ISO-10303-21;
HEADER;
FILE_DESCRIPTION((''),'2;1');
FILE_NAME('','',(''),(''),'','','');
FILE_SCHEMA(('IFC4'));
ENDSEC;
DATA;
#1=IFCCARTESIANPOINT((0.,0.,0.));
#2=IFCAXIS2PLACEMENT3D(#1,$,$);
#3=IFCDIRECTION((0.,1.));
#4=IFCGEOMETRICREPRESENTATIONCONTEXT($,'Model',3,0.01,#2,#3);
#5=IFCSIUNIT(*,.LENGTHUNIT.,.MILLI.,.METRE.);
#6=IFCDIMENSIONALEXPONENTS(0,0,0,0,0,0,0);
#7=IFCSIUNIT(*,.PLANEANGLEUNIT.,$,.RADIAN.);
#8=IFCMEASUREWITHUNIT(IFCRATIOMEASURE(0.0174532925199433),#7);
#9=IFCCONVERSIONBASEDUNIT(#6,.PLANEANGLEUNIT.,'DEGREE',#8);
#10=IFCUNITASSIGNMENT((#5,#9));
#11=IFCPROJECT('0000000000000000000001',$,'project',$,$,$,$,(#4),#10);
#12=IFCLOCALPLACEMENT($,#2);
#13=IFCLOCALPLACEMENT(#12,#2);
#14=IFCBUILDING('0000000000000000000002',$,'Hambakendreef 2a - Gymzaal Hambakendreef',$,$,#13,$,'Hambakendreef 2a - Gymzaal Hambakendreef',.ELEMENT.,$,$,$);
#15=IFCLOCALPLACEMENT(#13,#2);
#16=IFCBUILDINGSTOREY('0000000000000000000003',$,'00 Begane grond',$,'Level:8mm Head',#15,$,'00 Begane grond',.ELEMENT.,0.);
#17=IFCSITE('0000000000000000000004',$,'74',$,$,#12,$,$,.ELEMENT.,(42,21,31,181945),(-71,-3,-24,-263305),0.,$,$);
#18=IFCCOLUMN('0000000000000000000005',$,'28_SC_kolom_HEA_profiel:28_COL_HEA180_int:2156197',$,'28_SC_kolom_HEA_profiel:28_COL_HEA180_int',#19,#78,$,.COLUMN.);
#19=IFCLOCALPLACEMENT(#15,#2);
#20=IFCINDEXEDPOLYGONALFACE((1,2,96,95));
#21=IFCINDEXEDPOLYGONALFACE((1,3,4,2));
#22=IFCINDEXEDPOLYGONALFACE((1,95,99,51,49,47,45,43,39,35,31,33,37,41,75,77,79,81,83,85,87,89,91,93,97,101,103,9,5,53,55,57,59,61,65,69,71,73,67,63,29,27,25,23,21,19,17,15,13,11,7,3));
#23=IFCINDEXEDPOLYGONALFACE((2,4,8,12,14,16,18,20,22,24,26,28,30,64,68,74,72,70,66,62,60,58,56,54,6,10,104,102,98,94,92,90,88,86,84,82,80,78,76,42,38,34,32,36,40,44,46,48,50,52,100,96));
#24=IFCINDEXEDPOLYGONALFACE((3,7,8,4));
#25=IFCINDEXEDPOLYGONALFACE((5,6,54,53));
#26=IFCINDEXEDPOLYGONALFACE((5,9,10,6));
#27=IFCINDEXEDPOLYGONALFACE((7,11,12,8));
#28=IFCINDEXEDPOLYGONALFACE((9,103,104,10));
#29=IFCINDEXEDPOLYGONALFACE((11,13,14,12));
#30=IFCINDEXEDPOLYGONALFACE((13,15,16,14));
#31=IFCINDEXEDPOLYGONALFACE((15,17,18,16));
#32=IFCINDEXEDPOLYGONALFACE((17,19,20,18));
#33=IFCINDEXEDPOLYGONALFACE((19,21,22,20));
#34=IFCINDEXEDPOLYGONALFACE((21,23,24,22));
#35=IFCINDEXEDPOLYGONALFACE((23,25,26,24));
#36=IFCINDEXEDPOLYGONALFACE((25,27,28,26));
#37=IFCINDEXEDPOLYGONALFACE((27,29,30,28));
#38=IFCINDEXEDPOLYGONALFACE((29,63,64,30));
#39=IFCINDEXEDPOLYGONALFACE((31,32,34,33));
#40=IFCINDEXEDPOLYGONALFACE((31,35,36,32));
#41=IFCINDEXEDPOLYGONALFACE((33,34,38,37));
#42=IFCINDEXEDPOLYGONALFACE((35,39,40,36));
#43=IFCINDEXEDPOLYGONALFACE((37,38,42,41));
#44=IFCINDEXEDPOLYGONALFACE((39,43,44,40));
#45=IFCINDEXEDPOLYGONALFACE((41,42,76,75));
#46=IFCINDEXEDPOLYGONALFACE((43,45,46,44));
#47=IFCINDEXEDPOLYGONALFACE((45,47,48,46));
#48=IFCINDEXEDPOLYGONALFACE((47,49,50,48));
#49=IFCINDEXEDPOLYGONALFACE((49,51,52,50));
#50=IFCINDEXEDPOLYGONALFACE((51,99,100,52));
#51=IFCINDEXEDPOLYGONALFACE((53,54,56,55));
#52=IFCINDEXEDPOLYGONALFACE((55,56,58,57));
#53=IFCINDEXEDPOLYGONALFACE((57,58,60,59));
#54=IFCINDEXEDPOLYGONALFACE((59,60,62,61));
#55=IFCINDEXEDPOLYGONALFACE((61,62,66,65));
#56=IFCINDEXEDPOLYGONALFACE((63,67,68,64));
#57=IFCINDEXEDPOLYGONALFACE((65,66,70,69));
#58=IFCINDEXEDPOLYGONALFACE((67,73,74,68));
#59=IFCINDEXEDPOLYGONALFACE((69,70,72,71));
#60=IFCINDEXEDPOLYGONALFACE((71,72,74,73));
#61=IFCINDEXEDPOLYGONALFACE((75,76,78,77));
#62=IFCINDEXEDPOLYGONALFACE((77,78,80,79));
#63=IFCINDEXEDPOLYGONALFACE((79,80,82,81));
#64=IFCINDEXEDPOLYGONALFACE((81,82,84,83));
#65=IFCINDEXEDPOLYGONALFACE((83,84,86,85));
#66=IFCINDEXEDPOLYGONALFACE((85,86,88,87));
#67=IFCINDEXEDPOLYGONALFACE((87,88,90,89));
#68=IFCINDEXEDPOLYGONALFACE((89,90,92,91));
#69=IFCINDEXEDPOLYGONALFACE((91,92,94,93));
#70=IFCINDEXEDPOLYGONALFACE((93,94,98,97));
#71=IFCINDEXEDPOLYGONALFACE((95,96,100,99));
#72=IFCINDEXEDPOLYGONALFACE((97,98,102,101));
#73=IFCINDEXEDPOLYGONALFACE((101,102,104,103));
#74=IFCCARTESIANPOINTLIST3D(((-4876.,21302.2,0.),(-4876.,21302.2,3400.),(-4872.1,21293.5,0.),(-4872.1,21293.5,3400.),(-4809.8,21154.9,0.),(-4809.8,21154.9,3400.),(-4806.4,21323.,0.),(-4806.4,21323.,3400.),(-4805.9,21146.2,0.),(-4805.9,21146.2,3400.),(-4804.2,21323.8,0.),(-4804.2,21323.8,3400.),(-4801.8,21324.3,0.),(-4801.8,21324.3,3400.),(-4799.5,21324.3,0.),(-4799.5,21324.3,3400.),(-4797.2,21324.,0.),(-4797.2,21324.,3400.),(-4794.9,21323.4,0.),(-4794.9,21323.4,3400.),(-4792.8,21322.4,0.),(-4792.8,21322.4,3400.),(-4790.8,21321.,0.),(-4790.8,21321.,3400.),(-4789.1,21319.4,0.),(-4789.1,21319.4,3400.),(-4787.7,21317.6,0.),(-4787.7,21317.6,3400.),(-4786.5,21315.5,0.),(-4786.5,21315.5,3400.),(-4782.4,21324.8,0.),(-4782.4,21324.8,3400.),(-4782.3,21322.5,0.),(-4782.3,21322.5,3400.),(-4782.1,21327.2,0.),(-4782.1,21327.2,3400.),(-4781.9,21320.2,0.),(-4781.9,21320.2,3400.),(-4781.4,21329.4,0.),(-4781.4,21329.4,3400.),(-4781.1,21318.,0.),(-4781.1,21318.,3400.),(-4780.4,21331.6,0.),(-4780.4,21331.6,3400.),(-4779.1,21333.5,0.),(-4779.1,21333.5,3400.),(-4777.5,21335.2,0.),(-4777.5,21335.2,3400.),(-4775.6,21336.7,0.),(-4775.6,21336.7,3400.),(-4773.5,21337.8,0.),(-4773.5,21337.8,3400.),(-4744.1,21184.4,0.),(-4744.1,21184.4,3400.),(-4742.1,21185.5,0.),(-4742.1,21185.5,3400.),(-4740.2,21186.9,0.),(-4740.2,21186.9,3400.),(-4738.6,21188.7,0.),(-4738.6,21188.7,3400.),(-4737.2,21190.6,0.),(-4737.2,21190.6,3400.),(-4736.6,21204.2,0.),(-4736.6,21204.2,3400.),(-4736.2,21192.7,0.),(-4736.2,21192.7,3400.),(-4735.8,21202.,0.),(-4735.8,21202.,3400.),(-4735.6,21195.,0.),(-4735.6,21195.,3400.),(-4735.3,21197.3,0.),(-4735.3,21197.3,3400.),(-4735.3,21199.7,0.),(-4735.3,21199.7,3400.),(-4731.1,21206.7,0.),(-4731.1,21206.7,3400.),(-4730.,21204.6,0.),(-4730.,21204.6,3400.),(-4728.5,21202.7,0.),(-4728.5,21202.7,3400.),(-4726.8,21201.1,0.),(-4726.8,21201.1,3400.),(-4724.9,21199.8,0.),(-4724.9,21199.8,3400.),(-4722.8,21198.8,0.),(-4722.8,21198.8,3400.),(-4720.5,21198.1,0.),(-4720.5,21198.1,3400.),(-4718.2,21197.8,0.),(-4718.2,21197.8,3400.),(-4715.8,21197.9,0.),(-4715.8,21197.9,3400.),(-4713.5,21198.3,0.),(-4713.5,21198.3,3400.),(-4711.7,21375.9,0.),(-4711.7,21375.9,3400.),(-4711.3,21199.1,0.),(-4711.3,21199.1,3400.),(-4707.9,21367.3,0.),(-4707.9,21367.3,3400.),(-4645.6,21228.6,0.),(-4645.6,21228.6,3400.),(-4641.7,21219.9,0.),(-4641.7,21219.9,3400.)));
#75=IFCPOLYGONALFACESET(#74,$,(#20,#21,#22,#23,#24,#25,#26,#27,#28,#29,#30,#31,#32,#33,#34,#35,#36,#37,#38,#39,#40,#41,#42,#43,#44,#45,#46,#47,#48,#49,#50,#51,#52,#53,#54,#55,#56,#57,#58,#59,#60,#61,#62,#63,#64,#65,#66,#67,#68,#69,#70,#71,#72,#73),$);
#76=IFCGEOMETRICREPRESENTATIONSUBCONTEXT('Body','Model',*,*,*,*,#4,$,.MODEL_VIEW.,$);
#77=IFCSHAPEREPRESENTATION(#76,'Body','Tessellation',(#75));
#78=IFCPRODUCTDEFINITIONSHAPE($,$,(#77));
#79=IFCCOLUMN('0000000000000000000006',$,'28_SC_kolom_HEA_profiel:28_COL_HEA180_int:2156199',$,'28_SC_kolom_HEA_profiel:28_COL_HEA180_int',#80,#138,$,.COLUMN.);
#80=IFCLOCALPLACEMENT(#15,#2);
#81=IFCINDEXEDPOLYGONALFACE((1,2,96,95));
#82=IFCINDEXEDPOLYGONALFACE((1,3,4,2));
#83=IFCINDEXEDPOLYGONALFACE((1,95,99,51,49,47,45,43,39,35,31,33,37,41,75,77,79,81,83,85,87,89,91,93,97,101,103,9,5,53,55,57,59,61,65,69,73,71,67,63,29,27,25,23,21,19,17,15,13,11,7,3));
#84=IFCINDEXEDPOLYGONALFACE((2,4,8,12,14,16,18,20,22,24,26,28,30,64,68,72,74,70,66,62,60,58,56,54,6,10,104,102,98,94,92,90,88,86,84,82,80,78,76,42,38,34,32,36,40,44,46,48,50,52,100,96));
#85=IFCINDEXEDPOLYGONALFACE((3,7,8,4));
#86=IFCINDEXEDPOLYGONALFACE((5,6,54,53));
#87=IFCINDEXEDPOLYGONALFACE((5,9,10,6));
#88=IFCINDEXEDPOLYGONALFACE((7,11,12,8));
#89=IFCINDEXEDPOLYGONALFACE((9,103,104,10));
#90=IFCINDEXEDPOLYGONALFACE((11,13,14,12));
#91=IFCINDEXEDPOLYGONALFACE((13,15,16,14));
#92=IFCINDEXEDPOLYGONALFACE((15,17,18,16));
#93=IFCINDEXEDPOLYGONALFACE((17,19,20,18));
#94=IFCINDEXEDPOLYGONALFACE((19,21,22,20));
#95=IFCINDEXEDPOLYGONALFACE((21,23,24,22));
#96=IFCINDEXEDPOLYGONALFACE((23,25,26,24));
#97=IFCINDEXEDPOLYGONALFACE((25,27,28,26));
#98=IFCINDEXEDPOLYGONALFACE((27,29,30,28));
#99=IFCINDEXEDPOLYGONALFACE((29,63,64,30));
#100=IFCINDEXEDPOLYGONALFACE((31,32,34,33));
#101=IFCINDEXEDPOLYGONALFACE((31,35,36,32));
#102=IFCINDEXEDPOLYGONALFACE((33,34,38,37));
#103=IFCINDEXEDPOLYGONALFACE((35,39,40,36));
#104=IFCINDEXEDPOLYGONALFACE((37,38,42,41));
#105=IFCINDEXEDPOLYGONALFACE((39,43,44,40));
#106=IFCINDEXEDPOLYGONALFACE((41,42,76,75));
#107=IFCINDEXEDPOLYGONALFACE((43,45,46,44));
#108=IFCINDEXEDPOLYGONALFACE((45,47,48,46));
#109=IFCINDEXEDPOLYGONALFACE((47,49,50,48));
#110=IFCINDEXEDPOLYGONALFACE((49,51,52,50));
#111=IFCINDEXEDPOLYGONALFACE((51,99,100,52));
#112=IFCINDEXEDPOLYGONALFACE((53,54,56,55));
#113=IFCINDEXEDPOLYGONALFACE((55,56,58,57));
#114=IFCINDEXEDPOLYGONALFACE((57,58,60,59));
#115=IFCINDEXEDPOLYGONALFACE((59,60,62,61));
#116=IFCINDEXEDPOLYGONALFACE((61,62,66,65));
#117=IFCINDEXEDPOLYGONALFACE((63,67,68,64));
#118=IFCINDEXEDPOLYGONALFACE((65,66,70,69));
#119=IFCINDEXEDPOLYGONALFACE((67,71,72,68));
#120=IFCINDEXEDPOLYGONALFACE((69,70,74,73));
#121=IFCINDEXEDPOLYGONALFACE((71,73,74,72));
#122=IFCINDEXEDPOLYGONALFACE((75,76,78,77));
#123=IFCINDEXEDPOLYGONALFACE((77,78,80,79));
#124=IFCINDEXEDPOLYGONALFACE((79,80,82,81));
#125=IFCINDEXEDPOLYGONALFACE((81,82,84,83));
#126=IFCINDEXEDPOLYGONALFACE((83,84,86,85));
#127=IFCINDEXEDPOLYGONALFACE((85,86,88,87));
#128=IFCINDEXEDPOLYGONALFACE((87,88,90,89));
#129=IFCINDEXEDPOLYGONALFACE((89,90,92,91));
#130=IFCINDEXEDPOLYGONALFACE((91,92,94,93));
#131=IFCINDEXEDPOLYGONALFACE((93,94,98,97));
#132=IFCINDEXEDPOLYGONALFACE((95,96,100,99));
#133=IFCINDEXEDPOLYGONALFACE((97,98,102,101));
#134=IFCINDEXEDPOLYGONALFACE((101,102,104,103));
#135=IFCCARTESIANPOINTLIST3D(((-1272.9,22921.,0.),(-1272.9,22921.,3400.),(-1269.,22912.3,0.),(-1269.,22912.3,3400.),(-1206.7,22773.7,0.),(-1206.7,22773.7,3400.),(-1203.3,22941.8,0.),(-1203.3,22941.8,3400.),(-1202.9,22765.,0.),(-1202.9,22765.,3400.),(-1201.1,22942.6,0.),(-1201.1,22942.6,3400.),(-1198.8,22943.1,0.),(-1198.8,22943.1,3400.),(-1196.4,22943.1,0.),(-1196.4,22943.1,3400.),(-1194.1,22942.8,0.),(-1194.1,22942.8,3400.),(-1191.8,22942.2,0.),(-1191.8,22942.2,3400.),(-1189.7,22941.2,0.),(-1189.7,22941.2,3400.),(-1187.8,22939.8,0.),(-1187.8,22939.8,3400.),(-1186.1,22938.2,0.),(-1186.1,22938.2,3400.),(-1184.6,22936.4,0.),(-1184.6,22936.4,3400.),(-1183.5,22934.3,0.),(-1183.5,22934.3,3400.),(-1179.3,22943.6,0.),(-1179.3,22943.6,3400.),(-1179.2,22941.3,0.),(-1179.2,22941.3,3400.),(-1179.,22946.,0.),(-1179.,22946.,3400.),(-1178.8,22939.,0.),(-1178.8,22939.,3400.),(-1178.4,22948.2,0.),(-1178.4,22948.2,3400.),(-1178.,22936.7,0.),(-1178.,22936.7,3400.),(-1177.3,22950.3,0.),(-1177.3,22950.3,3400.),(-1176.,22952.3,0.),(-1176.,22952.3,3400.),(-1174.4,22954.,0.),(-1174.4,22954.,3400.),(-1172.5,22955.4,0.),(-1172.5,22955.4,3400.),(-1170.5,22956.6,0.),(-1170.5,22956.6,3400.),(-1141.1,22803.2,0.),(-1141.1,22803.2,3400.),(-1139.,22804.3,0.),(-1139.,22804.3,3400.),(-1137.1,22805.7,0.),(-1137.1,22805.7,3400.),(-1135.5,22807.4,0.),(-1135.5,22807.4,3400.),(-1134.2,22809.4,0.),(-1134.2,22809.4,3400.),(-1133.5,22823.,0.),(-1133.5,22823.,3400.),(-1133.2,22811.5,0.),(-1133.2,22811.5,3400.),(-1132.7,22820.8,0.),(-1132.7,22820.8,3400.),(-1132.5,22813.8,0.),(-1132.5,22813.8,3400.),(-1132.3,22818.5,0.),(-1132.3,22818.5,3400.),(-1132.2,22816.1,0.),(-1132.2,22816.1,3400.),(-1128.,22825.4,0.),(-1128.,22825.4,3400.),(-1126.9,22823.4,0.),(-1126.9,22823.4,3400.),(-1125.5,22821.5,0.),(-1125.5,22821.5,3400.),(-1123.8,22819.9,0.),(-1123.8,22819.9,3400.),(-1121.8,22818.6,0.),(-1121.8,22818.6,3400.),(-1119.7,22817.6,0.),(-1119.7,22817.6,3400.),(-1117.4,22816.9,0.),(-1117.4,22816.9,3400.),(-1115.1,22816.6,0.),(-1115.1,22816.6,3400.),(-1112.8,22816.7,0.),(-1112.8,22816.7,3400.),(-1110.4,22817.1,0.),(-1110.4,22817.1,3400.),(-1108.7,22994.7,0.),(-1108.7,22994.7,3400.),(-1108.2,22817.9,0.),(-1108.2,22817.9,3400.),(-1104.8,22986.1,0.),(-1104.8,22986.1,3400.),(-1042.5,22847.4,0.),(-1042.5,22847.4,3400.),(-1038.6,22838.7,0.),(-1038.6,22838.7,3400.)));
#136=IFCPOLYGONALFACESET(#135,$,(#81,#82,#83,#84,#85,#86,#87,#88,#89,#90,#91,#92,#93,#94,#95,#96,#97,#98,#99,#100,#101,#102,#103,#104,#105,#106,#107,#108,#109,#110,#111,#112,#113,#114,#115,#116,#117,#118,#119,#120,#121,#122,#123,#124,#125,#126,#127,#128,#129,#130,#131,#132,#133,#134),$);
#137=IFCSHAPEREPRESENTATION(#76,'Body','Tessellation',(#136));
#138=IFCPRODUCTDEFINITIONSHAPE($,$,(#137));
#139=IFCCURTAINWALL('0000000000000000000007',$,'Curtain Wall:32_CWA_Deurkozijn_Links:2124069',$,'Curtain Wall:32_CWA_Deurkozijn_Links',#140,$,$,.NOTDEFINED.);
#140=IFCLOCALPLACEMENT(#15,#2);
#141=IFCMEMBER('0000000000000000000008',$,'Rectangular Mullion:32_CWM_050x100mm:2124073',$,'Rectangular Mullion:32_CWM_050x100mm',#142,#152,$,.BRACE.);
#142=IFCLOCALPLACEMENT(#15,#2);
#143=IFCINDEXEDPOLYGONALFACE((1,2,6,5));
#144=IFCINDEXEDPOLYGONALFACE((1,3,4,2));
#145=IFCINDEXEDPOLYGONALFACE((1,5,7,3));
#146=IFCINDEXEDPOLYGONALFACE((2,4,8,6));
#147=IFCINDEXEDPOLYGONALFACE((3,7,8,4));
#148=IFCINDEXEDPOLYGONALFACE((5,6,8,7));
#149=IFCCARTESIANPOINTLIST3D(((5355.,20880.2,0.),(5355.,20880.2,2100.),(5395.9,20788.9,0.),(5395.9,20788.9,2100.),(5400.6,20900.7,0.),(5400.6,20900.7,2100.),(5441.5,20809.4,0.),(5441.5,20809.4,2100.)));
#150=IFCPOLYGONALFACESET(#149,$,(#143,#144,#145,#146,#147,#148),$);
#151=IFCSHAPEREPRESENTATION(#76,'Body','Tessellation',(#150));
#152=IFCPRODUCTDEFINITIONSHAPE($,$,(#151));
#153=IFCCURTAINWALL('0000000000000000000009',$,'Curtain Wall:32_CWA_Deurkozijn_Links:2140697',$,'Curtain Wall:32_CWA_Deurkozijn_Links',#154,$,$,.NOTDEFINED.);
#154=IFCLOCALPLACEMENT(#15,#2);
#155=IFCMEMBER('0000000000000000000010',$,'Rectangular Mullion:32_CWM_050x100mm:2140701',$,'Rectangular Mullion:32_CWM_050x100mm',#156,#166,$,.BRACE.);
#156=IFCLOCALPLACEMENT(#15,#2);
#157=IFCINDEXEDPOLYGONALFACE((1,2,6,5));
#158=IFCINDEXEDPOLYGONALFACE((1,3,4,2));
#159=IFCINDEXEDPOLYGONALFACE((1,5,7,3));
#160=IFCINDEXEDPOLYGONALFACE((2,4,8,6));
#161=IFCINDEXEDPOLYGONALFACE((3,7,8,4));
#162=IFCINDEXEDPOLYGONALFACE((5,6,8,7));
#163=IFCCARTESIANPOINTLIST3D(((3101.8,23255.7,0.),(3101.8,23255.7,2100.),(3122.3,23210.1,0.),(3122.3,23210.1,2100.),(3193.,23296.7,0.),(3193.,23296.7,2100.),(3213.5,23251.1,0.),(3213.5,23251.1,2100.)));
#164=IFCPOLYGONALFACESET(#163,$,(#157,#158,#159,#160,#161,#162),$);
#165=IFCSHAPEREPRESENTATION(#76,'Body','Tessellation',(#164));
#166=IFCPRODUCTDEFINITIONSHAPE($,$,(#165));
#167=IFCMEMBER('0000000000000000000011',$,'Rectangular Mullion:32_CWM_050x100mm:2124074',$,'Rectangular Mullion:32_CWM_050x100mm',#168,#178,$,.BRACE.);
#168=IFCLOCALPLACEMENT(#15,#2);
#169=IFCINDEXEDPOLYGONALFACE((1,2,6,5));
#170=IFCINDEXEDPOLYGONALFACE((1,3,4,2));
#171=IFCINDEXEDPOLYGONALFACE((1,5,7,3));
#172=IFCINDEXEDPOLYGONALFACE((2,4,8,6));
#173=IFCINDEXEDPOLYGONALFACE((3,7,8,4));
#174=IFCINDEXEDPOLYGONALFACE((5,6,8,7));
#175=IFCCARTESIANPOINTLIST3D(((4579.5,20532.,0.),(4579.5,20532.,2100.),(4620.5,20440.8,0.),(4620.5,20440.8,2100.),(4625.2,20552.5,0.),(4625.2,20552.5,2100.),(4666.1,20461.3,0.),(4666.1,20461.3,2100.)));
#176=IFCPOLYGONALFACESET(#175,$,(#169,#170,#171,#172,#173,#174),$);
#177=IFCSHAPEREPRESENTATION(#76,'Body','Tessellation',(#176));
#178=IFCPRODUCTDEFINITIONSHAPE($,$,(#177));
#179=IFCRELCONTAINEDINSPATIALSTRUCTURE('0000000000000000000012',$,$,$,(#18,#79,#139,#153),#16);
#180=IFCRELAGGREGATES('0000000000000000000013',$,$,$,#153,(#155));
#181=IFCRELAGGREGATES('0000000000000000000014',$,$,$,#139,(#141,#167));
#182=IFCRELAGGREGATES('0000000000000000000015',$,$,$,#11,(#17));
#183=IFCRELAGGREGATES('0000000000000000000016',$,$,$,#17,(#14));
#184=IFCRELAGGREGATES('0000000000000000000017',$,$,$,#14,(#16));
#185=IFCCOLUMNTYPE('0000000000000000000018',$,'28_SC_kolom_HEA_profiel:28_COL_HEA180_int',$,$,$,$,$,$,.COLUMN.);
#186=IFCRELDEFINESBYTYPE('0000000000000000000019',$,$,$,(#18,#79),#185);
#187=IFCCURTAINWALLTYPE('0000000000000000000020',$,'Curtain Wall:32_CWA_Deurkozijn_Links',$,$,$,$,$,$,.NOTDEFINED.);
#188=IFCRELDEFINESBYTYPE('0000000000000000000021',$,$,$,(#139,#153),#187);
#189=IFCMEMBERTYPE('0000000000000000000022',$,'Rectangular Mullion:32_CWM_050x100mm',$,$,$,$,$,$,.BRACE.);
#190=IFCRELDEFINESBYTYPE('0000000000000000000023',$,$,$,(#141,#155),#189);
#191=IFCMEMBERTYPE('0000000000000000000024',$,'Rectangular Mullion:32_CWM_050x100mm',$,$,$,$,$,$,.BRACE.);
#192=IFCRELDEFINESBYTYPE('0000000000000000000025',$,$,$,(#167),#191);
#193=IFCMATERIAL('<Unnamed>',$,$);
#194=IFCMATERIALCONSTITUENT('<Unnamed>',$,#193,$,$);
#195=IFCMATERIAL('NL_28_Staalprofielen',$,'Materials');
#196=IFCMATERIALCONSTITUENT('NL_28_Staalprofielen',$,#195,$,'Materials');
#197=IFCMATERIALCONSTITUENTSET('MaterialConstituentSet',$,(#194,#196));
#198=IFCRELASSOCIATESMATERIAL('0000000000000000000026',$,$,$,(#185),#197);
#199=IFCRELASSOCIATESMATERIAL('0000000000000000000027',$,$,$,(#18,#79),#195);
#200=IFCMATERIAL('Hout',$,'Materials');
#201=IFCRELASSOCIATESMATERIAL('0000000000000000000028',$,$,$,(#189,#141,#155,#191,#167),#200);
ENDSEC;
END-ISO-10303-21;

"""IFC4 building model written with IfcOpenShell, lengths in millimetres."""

from ifc_helpers import new_model, entity, si_unit, converted_unit, direction, frame, origin, place, context, subcontext, project, spatial, indexed_curve, outline, extrude, source, transform, mapped, material, constituent, constituent_set, type_object, type_shapes, element, aggregate, save


model = new_model("IFC4")

# Units and contexts
model_context = context("Model", 3, precision=0.01, world=origin(), true_north=direction((0.0, 1.0)))
body_context = subcontext(model_context, "Body", "Model", "MODEL_VIEW")
ifc_project = project(units=[si_unit("LENGTHUNIT", "METRE", prefix="MILLI"), converted_unit("PLANEANGLEUNIT", "DEGREE", entity("IfcRatioMeasure", 0.0174532925199433), si_unit("PLANEANGLEUNIT", "RADIAN"), dimensions=[0, 0, 0, 0, 0, 0, 0])], contexts=[model_context])

# Site, building, storey
site_placement = place(None, origin())
site = spatial("IfcSite", under=ifc_project, at=site_placement, Name="74", CompositionType="ELEMENT", RefLatitude=(42, 21, 31, 181945), RefLongitude=(-71, -3, -24, -263305), RefElevation=0.0)
building_placement = place(site_placement, origin())
building = spatial("IfcBuilding", under=site, at=building_placement, Name="Hambakendreef 2a - Gymzaal Hambakendreef", LongName="Hambakendreef 2a - Gymzaal Hambakendreef", CompositionType="ELEMENT")
storey_placement = place(building_placement, origin())
storey = spatial("IfcBuildingStorey", under=building, at=storey_placement, Name="00 Begane grond", ObjectType="Level:8mm Head", LongName="00 Begane grond", CompositionType="ELEMENT", Elevation=0.0)

# Columns
ifc_material_1 = material(Name="NL_28_Staalprofielen", Category="Materials")
ifc_material_2 = material(Name="<Unnamed>")
ifc_constituent_1 = constituent(ifc_material_2, Name="<Unnamed>")
ifc_constituent_2 = constituent(ifc_material_1, Name="NL_28_Staalprofielen", Category="Materials")
ifc_constituent_set_1 = constituent_set(constituents=[ifc_constituent_1, ifc_constituent_2], Name="MaterialConstituentSet")
column_type_1 = type_object("IfcColumnType", Name="28_SC_kolom_HEA_profiel:28_COL_HEA180_int", PredefinedType="COLUMN", material=ifc_constituent_set_1)
shared_shape_1 = source(origin(), body_context, "Body", "SweptSolid", [
    extrude(outline(indexed_curve([(-85.5, -90.0), (-76.0, -90.0), (-76.0, -18.0), (-75.8, -15.7), (-75.3, -13.4), (-74.4, -11.2), (-73.1, -9.2), (-71.6, -7.4), (-69.8, -5.9), (-67.8, -4.6), (-65.6, -3.7), (-63.3, -3.2), (-61.0, -3.0), (61.0, -3.0), (63.3, -3.2), (65.6, -3.7), (67.8, -4.6), (69.8, -5.9), (71.6, -7.4), (73.1, -9.2), (74.4, -11.2), (75.3, -13.4), (75.8, -15.7), (76.0, -18.0), (76.0, -90.0), (85.5, -90.0), (85.5, 90.0), (76.0, 90.0), (76.0, 18.0), (75.8, 15.7), (75.3, 13.4), (74.4, 11.2), (73.1, 9.2), (71.6, 7.4), (69.8, 5.9), (67.8, 4.6), (65.6, 3.7), (63.3, 3.2), (61.0, 3.0), (-61.0, 3.0), (-63.3, 3.2), (-65.6, 3.7), (-67.8, 4.6), (-69.8, 5.9), (-71.6, 7.4), (-73.1, 9.2), (-74.4, 11.2), (-75.3, 13.4), (-75.8, 15.7), (-76.0, 18.0), (-76.0, 90.0), (-85.5, 90.0), (-85.5, -90.0)], self_intersect=False)), frame((0.0, 0.0, 0.0), z_axis=(0.0, 0.0, 1.0), x_axis=(0.0, -1.0, 0.0)), (0.0, 0.0, 1.0), 3400.0),
])
type_shapes(column_type_1, [shared_shape_1])
for number, where, z_axis, x_axis, name in (
    (1, (-4758.8, 21261.1, 0.0), (0.0, 0.0, 1.0), (0.91227, 0.40959, 0.0), "28_SC_kolom_HEA_profiel:28_COL_HEA180_int:2156197"),
    (2, (-1155.8, 22879.9, 0.0), (0.0, 0.0, 1.0), (0.91227, 0.40959, 0.0), "28_SC_kolom_HEA_profiel:28_COL_HEA180_int:2156199"),
):
    element("IfcColumn", number, at=place(storey_placement, frame(where, z_axis=z_axis, x_axis=x_axis)), inside=storey, type_object=column_type_1, material=ifc_material_1, Name=name, ObjectType="28_SC_kolom_HEA_profiel:28_COL_HEA180_int", PredefinedType="COLUMN", context=body_context, shape_type="MappedRepresentation", body=[
        mapped(shared_shape_1, transform((0.0, 0.0, 0.0), scale=1.0)),
    ])

# Curtain walls, members
curtain_wall_type_1 = type_object("IfcCurtainWallType", Name="Curtain Wall:32_CWA_Deurkozijn_Links", PredefinedType="NOTDEFINED")
curtain_wall_1_placement = place(storey_placement, origin())
curtain_wall_1 = element("IfcCurtainWall", 3, at=curtain_wall_1_placement, inside=storey, type_object=curtain_wall_type_1, Name="Curtain Wall:32_CWA_Deurkozijn_Links:2124069", ObjectType="Curtain Wall:32_CWA_Deurkozijn_Links", PredefinedType="NOTDEFINED")
ifc_material_3 = material(Name="Hout", Category="Materials")
member_type_1 = type_object("IfcMemberType", Name="Rectangular Mullion:32_CWM_050x100mm", PredefinedType="BRACE", material=ifc_material_3)
shared_shape_2 = source(origin(), body_context, "Body", "SweptSolid", [
    extrude(outline(indexed_curve([(-50.0, -25.0), (50.0, -25.0), (50.0, 25.0), (-50.0, 25.0), (-50.0, -25.0)], self_intersect=False)), frame((-25.0, 0.0, -2100.0), z_axis=(0.0, 0.0, 1.0), x_axis=(0.0, -1.0, 0.0)), (0.0, 0.0, 1.0), 2100.0),
])
type_shapes(member_type_1, [shared_shape_2])
member_1_placement = place(storey_placement, frame((5421.1, 20855.0, 0.0), z_axis=(0.0, 0.0, -1.0), x_axis=(0.91227, 0.40959, 0.0)))
member_1 = element("IfcMember", 4, at=member_1_placement, type_object=member_type_1, material=ifc_material_3, Name="Rectangular Mullion:32_CWM_050x100mm:2124073", ObjectType="Rectangular Mullion:32_CWM_050x100mm", PredefinedType="BRACE", context=body_context, shape_type="MappedRepresentation", body=[
    mapped(shared_shape_2, transform((0.0, 0.0, 0.0), scale=1.0)),
])
curtain_wall_2_placement = place(storey_placement, origin())
curtain_wall_2 = element("IfcCurtainWall", 5, at=curtain_wall_2_placement, inside=storey, type_object=curtain_wall_type_1, Name="Curtain Wall:32_CWA_Deurkozijn_Links:2140697", ObjectType="Curtain Wall:32_CWA_Deurkozijn_Links", PredefinedType="NOTDEFINED")
member_2_placement = place(storey_placement, frame((3167.9, 23230.6, 0.0), z_axis=(0.0, 0.0, -1.0), x_axis=(0.40959, -0.91227, 0.0)))
member_2 = element("IfcMember", 6, at=member_2_placement, type_object=member_type_1, material=ifc_material_3, Name="Rectangular Mullion:32_CWM_050x100mm:2140701", ObjectType="Rectangular Mullion:32_CWM_050x100mm", PredefinedType="BRACE", context=body_context, shape_type="MappedRepresentation", body=[
    mapped(shared_shape_2, transform((0.0, 0.0, 0.0), scale=1.0)),
])

# Member
member_type_2 = type_object("IfcMemberType", Name="Rectangular Mullion:32_CWM_050x100mm", PredefinedType="BRACE", material=ifc_material_3)
shared_shape_3 = source(origin(), body_context, "Body", "SweptSolid", [
    extrude(outline(indexed_curve([(-50.0, -25.0), (50.0, -25.0), (50.0, 25.0), (-50.0, 25.0), (-50.0, -25.0)], self_intersect=False)), frame((-25.0, 0.0, -2100.0), z_axis=(0.0, 0.0, 1.0), x_axis=(0.0, -1.0, 0.0)), (0.0, 0.0, 1.0), 2100.0),
])
type_shapes(member_type_2, [shared_shape_3])
member_3_placement = place(storey_placement, frame((4600.0, 20486.4, 2100.0), z_axis=(0.0, 0.0, 1.0), x_axis=(-0.91227, -0.40959, 0.0)))
member_3 = element("IfcMember", 7, at=member_3_placement, type_object=member_type_2, material=ifc_material_3, Name="Rectangular Mullion:32_CWM_050x100mm:2124074", ObjectType="Rectangular Mullion:32_CWM_050x100mm", PredefinedType="BRACE", context=body_context, shape_type="MappedRepresentation", body=[
    mapped(shared_shape_3, transform((0.0, 0.0, 0.0), scale=1.0)),
])

aggregate(curtain_wall_2, [member_2])
aggregate(curtain_wall_1, [member_1, member_3])

save(model, "model.ifc")
